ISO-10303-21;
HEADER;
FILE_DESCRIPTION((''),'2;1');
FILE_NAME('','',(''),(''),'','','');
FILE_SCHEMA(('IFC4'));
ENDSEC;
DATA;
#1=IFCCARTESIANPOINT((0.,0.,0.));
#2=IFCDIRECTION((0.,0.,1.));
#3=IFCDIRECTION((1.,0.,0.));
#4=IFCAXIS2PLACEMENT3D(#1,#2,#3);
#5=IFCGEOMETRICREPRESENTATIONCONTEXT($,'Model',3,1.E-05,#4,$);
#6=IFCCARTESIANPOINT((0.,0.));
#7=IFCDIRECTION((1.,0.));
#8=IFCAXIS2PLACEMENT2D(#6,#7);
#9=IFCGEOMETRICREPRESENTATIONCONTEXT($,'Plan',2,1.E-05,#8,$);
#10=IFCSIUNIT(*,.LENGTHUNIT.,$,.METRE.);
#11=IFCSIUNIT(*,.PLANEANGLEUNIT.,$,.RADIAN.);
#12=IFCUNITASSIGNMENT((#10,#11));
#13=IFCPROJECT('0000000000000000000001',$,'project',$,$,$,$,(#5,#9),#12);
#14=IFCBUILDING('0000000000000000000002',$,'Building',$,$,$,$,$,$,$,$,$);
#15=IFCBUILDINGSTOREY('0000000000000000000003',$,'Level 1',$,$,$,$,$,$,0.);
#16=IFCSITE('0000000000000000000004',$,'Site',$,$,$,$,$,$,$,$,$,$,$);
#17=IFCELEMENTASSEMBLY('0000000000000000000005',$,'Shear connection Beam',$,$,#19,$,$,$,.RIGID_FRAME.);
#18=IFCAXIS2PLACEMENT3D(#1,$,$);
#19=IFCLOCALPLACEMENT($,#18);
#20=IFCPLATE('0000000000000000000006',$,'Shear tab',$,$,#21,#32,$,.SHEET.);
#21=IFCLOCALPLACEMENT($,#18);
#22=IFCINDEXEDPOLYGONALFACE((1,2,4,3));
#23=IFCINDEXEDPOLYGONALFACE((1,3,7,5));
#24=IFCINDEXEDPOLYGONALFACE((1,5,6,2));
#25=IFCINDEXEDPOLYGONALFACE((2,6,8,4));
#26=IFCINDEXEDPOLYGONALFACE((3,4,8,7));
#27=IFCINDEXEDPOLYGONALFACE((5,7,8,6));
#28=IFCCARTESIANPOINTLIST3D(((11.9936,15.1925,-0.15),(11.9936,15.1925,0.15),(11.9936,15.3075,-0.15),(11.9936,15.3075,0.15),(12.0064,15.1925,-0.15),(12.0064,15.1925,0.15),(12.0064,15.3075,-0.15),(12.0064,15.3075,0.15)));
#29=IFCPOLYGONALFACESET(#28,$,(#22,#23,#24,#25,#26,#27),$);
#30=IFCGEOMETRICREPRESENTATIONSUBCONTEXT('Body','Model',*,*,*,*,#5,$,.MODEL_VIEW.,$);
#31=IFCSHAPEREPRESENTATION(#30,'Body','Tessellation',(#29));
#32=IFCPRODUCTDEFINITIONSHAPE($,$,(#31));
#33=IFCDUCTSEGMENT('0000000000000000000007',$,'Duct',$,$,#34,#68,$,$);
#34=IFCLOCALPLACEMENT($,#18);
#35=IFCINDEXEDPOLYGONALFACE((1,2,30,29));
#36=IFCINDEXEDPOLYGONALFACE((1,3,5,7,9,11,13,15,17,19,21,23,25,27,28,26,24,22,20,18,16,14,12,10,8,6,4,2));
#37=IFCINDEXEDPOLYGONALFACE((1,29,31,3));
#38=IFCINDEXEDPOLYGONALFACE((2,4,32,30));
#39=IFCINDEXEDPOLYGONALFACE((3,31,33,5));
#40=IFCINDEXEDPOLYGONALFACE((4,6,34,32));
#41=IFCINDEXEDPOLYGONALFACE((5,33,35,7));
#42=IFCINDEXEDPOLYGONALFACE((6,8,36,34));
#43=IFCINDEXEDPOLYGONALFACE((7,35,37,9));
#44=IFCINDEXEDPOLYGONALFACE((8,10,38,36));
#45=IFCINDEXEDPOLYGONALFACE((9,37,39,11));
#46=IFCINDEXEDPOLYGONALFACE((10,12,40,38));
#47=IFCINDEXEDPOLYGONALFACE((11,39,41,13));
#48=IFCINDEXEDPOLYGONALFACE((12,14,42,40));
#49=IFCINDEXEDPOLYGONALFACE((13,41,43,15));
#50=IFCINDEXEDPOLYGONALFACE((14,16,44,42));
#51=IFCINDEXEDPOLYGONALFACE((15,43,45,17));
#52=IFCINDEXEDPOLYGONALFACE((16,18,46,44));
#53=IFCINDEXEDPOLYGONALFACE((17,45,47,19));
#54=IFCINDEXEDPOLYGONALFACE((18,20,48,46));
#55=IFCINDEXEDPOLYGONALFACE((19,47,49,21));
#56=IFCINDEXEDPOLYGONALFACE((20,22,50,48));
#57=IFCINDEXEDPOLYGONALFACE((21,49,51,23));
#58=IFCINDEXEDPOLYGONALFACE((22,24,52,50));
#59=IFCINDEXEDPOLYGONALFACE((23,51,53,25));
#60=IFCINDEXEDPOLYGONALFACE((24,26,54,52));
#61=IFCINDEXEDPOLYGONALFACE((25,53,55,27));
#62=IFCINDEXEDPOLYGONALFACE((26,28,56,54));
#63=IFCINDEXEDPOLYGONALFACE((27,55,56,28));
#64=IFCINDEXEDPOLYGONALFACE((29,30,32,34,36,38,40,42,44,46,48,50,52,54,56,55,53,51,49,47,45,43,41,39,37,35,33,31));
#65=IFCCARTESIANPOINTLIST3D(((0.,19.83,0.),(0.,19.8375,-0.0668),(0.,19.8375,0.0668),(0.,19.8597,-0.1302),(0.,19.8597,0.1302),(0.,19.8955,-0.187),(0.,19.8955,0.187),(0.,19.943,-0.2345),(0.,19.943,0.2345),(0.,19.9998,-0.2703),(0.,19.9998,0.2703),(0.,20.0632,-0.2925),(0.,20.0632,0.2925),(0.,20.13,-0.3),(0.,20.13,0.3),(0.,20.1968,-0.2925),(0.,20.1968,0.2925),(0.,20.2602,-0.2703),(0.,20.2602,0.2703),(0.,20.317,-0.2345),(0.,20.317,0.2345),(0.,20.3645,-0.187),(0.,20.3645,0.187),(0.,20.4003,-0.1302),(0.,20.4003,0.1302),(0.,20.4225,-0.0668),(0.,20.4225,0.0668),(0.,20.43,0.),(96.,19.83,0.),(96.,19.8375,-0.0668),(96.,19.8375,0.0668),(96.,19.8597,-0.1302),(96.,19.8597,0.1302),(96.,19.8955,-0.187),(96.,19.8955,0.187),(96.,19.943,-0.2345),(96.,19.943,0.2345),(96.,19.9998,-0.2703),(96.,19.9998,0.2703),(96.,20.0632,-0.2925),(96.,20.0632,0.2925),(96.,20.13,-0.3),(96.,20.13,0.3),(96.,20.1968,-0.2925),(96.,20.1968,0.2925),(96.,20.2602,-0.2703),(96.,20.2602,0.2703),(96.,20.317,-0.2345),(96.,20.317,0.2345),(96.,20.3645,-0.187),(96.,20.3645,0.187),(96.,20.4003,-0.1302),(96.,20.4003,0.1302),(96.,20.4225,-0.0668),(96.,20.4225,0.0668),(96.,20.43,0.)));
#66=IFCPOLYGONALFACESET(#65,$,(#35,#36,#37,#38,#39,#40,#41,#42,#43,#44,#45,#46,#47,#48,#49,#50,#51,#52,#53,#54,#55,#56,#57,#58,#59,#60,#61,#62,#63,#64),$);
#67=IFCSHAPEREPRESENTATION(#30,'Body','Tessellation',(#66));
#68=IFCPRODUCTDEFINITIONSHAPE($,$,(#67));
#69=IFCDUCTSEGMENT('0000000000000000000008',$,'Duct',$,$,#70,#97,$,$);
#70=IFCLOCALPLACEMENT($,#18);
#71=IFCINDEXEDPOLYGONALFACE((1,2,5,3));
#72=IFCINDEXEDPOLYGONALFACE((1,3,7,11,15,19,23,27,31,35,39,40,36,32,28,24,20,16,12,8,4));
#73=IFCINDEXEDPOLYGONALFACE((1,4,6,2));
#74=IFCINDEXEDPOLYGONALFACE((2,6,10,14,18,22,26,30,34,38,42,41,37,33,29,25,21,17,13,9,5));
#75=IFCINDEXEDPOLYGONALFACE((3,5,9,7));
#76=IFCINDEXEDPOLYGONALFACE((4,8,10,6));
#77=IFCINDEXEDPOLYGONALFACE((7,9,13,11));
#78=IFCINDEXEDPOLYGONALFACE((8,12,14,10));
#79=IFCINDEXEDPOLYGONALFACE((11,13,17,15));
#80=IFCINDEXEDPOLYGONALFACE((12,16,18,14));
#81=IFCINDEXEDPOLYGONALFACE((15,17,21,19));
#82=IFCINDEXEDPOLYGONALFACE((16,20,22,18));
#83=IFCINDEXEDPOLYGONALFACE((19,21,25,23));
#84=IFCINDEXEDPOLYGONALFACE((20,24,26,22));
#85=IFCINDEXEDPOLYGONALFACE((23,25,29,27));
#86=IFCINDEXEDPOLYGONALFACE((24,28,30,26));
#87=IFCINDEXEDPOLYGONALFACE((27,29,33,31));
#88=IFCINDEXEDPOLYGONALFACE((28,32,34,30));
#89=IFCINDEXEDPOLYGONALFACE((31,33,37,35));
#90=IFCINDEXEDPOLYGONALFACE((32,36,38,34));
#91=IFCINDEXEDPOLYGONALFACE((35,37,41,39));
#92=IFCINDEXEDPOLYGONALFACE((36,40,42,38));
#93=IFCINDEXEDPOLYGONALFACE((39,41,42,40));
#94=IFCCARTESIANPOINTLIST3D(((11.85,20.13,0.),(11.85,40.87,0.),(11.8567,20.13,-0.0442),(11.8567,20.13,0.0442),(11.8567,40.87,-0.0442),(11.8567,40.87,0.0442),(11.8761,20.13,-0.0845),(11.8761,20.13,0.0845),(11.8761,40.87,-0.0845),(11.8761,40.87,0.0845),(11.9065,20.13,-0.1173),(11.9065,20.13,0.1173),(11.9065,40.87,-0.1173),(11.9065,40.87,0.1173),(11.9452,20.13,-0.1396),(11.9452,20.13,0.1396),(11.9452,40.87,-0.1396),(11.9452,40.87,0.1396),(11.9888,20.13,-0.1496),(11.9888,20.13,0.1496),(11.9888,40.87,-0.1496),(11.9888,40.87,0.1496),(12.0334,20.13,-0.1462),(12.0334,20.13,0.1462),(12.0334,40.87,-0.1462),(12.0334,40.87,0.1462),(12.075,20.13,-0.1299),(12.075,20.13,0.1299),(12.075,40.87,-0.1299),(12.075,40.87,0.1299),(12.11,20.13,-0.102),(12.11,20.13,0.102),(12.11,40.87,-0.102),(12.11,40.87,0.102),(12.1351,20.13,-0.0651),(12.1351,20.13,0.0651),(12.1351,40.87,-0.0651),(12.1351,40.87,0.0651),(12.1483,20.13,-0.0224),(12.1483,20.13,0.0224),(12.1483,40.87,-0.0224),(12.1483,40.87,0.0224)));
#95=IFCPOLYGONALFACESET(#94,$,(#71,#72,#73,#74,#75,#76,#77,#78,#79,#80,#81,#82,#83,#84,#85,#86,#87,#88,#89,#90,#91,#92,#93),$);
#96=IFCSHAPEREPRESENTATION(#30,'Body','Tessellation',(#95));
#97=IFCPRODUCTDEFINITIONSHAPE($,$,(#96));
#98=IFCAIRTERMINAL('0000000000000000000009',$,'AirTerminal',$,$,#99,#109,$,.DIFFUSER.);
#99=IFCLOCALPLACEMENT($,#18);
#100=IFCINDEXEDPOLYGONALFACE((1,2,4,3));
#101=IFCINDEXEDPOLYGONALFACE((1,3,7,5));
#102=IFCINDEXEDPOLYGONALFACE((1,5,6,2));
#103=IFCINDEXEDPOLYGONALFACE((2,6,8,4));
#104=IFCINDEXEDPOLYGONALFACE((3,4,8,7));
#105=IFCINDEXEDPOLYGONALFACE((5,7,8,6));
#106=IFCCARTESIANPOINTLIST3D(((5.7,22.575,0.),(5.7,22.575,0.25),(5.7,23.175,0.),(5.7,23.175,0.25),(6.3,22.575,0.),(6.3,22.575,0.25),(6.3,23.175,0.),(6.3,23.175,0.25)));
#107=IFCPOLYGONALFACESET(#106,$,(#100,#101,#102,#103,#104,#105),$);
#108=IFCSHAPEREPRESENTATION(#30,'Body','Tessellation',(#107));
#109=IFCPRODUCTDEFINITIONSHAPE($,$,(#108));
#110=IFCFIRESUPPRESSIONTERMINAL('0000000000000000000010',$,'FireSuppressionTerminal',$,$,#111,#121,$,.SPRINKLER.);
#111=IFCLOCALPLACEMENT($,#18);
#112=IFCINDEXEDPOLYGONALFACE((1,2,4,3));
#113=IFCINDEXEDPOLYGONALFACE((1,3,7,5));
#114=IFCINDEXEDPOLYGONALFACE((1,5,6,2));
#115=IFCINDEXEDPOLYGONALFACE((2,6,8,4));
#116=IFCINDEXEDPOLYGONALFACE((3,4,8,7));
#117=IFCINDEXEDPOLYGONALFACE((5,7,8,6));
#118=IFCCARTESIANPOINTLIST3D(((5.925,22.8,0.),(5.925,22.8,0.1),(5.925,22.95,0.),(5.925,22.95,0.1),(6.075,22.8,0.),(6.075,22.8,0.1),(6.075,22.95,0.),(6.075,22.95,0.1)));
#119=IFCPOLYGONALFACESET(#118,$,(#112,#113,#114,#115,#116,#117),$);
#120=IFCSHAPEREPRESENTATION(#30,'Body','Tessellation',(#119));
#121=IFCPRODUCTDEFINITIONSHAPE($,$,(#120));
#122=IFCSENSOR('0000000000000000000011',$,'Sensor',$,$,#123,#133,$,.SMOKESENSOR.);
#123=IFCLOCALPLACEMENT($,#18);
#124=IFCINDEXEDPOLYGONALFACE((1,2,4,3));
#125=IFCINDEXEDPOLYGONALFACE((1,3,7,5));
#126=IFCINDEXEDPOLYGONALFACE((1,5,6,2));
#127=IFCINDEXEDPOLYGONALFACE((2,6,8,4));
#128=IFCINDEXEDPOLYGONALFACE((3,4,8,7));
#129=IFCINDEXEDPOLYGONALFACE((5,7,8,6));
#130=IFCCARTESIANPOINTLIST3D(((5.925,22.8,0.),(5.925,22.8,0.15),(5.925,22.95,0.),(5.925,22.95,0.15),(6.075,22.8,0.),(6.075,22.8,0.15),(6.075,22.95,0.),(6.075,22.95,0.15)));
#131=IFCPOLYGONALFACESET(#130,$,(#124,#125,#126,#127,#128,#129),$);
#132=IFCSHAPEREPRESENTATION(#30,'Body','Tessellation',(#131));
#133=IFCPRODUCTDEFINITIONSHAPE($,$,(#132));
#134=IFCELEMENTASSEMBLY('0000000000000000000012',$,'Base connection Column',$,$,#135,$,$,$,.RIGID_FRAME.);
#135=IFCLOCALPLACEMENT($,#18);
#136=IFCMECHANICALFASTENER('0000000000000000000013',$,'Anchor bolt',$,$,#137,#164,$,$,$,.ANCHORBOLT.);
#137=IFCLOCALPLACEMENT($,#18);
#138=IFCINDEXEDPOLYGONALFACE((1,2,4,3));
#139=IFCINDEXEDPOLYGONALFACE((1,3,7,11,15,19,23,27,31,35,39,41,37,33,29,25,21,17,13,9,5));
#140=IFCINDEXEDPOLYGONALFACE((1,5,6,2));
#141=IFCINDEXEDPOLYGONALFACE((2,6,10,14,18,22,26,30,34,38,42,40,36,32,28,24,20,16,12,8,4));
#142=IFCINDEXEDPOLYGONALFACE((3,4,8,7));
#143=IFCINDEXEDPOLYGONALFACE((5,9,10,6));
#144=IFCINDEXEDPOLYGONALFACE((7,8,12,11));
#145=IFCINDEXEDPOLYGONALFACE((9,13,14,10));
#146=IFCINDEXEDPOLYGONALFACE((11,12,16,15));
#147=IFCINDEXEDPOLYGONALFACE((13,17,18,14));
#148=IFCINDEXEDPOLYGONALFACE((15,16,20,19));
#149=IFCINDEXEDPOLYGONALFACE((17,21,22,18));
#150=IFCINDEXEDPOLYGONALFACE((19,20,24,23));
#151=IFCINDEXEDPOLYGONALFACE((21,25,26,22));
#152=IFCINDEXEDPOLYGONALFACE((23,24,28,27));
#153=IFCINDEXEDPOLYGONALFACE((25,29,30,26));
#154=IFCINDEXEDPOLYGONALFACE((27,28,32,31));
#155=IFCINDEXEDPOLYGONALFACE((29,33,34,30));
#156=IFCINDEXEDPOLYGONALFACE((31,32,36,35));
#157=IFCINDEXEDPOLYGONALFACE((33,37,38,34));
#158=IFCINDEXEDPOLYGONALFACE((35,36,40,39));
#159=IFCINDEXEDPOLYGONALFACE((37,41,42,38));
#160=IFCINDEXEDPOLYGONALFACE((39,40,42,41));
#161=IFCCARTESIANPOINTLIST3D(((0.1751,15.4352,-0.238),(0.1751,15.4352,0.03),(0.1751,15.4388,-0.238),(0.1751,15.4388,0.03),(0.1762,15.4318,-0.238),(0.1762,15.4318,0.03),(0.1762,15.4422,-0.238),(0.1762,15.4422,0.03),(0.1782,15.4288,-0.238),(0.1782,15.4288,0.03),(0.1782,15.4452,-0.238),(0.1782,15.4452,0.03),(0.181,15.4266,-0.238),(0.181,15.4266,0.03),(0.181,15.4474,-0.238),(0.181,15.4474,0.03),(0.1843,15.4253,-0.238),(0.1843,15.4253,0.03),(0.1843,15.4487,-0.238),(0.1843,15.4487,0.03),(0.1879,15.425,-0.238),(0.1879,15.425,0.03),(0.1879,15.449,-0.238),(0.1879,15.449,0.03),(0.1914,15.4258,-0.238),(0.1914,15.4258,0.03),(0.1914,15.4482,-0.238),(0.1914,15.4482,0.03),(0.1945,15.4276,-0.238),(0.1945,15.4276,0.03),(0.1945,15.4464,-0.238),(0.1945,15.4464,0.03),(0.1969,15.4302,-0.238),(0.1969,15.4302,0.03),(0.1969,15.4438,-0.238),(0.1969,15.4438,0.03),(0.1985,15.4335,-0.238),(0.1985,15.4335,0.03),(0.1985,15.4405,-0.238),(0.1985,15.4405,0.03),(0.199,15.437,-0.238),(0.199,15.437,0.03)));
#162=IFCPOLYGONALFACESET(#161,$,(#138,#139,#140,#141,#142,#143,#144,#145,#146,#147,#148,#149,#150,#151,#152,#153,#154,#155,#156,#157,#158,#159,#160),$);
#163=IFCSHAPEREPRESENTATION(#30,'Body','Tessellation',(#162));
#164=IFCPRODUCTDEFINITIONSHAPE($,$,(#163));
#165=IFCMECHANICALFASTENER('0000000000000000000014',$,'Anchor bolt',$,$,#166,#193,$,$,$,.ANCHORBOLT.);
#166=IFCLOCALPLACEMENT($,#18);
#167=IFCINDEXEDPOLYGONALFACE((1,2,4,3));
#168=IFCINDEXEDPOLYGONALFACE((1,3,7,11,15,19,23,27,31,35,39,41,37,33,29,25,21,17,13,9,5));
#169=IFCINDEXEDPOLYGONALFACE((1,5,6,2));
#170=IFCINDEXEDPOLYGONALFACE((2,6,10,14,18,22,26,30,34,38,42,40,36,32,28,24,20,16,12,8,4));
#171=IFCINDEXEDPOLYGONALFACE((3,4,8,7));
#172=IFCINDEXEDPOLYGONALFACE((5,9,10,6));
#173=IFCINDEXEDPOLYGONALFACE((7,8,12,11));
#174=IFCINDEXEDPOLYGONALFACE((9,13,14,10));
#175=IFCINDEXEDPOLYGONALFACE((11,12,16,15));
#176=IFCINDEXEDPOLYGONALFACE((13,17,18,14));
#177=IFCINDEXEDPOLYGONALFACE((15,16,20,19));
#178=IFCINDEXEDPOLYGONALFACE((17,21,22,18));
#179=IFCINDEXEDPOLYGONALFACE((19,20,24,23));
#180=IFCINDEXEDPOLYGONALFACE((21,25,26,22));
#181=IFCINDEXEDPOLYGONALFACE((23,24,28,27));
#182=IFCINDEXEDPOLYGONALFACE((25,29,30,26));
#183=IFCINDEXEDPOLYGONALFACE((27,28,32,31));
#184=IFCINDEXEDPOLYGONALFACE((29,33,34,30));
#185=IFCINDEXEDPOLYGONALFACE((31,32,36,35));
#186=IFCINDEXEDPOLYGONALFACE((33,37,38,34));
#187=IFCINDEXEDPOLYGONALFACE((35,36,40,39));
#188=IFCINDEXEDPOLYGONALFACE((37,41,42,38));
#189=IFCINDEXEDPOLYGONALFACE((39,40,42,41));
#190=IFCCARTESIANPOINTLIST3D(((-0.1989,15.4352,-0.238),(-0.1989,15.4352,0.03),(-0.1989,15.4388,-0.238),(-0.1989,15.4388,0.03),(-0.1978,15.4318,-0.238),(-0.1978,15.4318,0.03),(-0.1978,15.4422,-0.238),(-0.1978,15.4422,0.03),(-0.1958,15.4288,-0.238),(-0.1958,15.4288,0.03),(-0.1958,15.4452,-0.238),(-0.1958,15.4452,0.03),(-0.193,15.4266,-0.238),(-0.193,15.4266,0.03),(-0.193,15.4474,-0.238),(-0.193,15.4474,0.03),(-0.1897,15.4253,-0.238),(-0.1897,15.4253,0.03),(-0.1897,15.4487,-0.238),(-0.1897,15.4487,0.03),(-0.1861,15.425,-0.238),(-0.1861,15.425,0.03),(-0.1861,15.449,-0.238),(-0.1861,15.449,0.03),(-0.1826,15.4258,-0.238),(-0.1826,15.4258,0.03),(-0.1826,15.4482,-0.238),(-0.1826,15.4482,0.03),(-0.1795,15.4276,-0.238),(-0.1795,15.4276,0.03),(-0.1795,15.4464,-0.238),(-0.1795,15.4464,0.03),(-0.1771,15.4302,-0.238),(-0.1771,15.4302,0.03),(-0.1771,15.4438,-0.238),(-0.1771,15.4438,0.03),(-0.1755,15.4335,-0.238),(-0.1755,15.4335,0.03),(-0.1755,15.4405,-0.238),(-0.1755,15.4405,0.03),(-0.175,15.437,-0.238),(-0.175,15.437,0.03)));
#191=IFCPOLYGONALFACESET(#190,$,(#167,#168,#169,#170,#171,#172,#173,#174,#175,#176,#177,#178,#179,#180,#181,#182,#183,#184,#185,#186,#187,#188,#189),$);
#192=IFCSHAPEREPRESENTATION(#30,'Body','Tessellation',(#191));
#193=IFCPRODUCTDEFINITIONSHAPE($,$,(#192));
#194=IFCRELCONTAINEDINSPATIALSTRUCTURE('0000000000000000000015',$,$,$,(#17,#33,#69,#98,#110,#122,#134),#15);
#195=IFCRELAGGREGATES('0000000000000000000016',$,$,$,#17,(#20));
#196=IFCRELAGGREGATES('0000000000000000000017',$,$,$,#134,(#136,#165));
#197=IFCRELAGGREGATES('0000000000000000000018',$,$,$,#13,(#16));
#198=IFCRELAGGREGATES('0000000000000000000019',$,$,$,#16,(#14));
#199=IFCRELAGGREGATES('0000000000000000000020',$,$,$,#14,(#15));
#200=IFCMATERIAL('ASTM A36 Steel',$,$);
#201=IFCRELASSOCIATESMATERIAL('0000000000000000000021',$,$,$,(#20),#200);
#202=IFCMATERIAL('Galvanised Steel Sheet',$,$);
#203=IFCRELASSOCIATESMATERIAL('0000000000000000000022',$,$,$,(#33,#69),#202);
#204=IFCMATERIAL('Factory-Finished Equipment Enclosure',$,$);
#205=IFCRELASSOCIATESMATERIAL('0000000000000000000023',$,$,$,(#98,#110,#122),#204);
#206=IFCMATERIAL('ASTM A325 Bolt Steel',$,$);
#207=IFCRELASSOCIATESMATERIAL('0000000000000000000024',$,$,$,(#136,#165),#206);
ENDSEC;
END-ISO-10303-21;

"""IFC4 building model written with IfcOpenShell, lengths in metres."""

from ifc_helpers import new_model, si_unit, frame, origin_with_axes, origin_2d, origin_2d_with_axis, place, context, subcontext, project, spatial, rectangle, circle, extrude, material, element, aggregate, save


model = new_model("IFC4")

# Units and contexts
model_context = context("Model", 3, precision=1e-05, world=origin_with_axes())
plan_context = context("Plan", 2, precision=1e-05, world=origin_2d_with_axis())
body_context = subcontext(model_context, "Body", "Model", "MODEL_VIEW")
ifc_project = project(units=[si_unit("LENGTHUNIT", "METRE"), si_unit("PLANEANGLEUNIT", "RADIAN")], contexts=[model_context, plan_context])

# Site, building, storey
site = spatial("IfcSite", under=ifc_project, Name="Site")
building = spatial("IfcBuilding", under=site, Name="Building")
storey = spatial("IfcBuildingStorey", under=building, Name="Level 1", Elevation=0.0)

# Element assembly, plate
assembly_1 = element("IfcElementAssembly", 1, inside=storey, Name="Shear connection Beam", PredefinedType="RIGID_FRAME")
ifc_material_1 = material(Name="ASTM A36 Steel")
plate_1_placement = place(None, frame((12.0, 15.25, -0.15), z_axis=(0.0, 0.0, 1.0), x_axis=(1.0, 0.0, 0.0)))
plate_1 = element("IfcPlate", 2, at=plate_1_placement, material=ifc_material_1, Name="Shear tab", PredefinedType="SHEET", context=body_context, shape_type="SweptSolid", body=[
    extrude(rectangle(XDim=0.0127, YDim=0.115, at=origin_2d_with_axis()), origin_with_axes(), (0.0, 0.0, 1.0), 0.3),
])
aggregate(assembly_1, [plate_1])

# Duct segments
ifc_material_2 = material(Name="Galvanised Steel Sheet")
duct_segment_1_placement = place(None, frame((0.0, 20.13, 0.0), z_axis=(1.0, 0.0, 0.0), x_axis=(0.0, 1.0, 0.0)))
element("IfcDuctSegment", 3, at=duct_segment_1_placement, inside=storey, material=ifc_material_2, Name="Duct", context=body_context, shape_type="SweptSolid", body=[
    extrude(circle(Radius=0.3, at=origin_2d_with_axis()), origin_with_axes(), (0.0, 0.0, 1.0), 96.0),
])
duct_segment_2_placement = place(None, frame((12.0, 20.13, 0.0), z_axis=(0.0, 1.0, 0.0), x_axis=(-1.0, 0.0, 0.0)))
element("IfcDuctSegment", 4, at=duct_segment_2_placement, inside=storey, material=ifc_material_2, Name="Duct", context=body_context, shape_type="SweptSolid", body=[
    extrude(circle(Radius=0.15, at=origin_2d_with_axis()), origin_with_axes(), (0.0, 0.0, 1.0), 20.74),
])

# Air terminal
ifc_material_3 = material(Name="Factory-Finished Equipment Enclosure")
air_terminal_placement = place(None, frame((6.0, 22.875, 0.0), z_axis=(0.0, 0.0, 1.0), x_axis=(1.0, 0.0, 0.0)))
element("IfcAirTerminal", 5, at=air_terminal_placement, inside=storey, material=ifc_material_3, Name="AirTerminal", PredefinedType="DIFFUSER", context=body_context, shape_type="SweptSolid", body=[
    extrude(rectangle(XDim=0.6, YDim=0.6, at=origin_2d_with_axis()), origin_with_axes(), (0.0, 0.0, 1.0), 0.25),
])

# Fire suppression terminal
fire_suppression_terminal_placement = place(None, frame((6.0, 22.875, 0.0), z_axis=(0.0, 0.0, 1.0), x_axis=(1.0, 0.0, 0.0)))
element("IfcFireSuppressionTerminal", 6, at=fire_suppression_terminal_placement, inside=storey, material=ifc_material_3, Name="FireSuppressionTerminal", PredefinedType="SPRINKLER", context=body_context, shape_type="SweptSolid", body=[
    extrude(rectangle(XDim=0.15, YDim=0.15, at=origin_2d_with_axis()), origin_with_axes(), (0.0, 0.0, 1.0), 0.1),
])

# Sensor
sensor_placement = place(None, frame((6.0, 22.875, 0.0), z_axis=(0.0, 0.0, 1.0), x_axis=(1.0, 0.0, 0.0)))
element("IfcSensor", 7, at=sensor_placement, inside=storey, material=ifc_material_3, Name="Sensor", PredefinedType="SMOKESENSOR", context=body_context, shape_type="SweptSolid", body=[
    extrude(rectangle(XDim=0.15, YDim=0.15, at=origin_2d_with_axis()), origin_with_axes(), (0.0, 0.0, 1.0), 0.15),
])

# Element assembly, mechanical fasteners
assembly_2 = element("IfcElementAssembly", 8, inside=storey, Name="Base connection Column", PredefinedType="RIGID_FRAME")
ifc_material_4 = material(Name="ASTM A325 Bolt Steel")
mechanical_fastener_1_placement = place(None, frame((0.187, 15.437, -0.238), z_axis=(0.0, 0.0, 1.0), x_axis=(1.0, 0.0, 0.0)))
mechanical_fastener_1 = element("IfcMechanicalFastener", 9, at=mechanical_fastener_1_placement, material=ifc_material_4, Name="Anchor bolt", PredefinedType="ANCHORBOLT", context=body_context, shape_type="SweptSolid", body=[
    extrude(circle(Radius=0.012, at=origin_2d()), origin_with_axes(), (0.0, 0.0, 1.0), 0.268),
])
mechanical_fastener_2_placement = place(None, frame((-0.187, 15.437, -0.238), z_axis=(0.0, 0.0, 1.0), x_axis=(1.0, 0.0, 0.0)))
mechanical_fastener_2 = element("IfcMechanicalFastener", 10, at=mechanical_fastener_2_placement, material=ifc_material_4, Name="Anchor bolt", PredefinedType="ANCHORBOLT", context=body_context, shape_type="SweptSolid", body=[
    extrude(circle(Radius=0.012, at=origin_2d()), origin_with_axes(), (0.0, 0.0, 1.0), 0.268),
])
aggregate(assembly_2, [mechanical_fastener_1, mechanical_fastener_2])

save(model, "model.ifc")
